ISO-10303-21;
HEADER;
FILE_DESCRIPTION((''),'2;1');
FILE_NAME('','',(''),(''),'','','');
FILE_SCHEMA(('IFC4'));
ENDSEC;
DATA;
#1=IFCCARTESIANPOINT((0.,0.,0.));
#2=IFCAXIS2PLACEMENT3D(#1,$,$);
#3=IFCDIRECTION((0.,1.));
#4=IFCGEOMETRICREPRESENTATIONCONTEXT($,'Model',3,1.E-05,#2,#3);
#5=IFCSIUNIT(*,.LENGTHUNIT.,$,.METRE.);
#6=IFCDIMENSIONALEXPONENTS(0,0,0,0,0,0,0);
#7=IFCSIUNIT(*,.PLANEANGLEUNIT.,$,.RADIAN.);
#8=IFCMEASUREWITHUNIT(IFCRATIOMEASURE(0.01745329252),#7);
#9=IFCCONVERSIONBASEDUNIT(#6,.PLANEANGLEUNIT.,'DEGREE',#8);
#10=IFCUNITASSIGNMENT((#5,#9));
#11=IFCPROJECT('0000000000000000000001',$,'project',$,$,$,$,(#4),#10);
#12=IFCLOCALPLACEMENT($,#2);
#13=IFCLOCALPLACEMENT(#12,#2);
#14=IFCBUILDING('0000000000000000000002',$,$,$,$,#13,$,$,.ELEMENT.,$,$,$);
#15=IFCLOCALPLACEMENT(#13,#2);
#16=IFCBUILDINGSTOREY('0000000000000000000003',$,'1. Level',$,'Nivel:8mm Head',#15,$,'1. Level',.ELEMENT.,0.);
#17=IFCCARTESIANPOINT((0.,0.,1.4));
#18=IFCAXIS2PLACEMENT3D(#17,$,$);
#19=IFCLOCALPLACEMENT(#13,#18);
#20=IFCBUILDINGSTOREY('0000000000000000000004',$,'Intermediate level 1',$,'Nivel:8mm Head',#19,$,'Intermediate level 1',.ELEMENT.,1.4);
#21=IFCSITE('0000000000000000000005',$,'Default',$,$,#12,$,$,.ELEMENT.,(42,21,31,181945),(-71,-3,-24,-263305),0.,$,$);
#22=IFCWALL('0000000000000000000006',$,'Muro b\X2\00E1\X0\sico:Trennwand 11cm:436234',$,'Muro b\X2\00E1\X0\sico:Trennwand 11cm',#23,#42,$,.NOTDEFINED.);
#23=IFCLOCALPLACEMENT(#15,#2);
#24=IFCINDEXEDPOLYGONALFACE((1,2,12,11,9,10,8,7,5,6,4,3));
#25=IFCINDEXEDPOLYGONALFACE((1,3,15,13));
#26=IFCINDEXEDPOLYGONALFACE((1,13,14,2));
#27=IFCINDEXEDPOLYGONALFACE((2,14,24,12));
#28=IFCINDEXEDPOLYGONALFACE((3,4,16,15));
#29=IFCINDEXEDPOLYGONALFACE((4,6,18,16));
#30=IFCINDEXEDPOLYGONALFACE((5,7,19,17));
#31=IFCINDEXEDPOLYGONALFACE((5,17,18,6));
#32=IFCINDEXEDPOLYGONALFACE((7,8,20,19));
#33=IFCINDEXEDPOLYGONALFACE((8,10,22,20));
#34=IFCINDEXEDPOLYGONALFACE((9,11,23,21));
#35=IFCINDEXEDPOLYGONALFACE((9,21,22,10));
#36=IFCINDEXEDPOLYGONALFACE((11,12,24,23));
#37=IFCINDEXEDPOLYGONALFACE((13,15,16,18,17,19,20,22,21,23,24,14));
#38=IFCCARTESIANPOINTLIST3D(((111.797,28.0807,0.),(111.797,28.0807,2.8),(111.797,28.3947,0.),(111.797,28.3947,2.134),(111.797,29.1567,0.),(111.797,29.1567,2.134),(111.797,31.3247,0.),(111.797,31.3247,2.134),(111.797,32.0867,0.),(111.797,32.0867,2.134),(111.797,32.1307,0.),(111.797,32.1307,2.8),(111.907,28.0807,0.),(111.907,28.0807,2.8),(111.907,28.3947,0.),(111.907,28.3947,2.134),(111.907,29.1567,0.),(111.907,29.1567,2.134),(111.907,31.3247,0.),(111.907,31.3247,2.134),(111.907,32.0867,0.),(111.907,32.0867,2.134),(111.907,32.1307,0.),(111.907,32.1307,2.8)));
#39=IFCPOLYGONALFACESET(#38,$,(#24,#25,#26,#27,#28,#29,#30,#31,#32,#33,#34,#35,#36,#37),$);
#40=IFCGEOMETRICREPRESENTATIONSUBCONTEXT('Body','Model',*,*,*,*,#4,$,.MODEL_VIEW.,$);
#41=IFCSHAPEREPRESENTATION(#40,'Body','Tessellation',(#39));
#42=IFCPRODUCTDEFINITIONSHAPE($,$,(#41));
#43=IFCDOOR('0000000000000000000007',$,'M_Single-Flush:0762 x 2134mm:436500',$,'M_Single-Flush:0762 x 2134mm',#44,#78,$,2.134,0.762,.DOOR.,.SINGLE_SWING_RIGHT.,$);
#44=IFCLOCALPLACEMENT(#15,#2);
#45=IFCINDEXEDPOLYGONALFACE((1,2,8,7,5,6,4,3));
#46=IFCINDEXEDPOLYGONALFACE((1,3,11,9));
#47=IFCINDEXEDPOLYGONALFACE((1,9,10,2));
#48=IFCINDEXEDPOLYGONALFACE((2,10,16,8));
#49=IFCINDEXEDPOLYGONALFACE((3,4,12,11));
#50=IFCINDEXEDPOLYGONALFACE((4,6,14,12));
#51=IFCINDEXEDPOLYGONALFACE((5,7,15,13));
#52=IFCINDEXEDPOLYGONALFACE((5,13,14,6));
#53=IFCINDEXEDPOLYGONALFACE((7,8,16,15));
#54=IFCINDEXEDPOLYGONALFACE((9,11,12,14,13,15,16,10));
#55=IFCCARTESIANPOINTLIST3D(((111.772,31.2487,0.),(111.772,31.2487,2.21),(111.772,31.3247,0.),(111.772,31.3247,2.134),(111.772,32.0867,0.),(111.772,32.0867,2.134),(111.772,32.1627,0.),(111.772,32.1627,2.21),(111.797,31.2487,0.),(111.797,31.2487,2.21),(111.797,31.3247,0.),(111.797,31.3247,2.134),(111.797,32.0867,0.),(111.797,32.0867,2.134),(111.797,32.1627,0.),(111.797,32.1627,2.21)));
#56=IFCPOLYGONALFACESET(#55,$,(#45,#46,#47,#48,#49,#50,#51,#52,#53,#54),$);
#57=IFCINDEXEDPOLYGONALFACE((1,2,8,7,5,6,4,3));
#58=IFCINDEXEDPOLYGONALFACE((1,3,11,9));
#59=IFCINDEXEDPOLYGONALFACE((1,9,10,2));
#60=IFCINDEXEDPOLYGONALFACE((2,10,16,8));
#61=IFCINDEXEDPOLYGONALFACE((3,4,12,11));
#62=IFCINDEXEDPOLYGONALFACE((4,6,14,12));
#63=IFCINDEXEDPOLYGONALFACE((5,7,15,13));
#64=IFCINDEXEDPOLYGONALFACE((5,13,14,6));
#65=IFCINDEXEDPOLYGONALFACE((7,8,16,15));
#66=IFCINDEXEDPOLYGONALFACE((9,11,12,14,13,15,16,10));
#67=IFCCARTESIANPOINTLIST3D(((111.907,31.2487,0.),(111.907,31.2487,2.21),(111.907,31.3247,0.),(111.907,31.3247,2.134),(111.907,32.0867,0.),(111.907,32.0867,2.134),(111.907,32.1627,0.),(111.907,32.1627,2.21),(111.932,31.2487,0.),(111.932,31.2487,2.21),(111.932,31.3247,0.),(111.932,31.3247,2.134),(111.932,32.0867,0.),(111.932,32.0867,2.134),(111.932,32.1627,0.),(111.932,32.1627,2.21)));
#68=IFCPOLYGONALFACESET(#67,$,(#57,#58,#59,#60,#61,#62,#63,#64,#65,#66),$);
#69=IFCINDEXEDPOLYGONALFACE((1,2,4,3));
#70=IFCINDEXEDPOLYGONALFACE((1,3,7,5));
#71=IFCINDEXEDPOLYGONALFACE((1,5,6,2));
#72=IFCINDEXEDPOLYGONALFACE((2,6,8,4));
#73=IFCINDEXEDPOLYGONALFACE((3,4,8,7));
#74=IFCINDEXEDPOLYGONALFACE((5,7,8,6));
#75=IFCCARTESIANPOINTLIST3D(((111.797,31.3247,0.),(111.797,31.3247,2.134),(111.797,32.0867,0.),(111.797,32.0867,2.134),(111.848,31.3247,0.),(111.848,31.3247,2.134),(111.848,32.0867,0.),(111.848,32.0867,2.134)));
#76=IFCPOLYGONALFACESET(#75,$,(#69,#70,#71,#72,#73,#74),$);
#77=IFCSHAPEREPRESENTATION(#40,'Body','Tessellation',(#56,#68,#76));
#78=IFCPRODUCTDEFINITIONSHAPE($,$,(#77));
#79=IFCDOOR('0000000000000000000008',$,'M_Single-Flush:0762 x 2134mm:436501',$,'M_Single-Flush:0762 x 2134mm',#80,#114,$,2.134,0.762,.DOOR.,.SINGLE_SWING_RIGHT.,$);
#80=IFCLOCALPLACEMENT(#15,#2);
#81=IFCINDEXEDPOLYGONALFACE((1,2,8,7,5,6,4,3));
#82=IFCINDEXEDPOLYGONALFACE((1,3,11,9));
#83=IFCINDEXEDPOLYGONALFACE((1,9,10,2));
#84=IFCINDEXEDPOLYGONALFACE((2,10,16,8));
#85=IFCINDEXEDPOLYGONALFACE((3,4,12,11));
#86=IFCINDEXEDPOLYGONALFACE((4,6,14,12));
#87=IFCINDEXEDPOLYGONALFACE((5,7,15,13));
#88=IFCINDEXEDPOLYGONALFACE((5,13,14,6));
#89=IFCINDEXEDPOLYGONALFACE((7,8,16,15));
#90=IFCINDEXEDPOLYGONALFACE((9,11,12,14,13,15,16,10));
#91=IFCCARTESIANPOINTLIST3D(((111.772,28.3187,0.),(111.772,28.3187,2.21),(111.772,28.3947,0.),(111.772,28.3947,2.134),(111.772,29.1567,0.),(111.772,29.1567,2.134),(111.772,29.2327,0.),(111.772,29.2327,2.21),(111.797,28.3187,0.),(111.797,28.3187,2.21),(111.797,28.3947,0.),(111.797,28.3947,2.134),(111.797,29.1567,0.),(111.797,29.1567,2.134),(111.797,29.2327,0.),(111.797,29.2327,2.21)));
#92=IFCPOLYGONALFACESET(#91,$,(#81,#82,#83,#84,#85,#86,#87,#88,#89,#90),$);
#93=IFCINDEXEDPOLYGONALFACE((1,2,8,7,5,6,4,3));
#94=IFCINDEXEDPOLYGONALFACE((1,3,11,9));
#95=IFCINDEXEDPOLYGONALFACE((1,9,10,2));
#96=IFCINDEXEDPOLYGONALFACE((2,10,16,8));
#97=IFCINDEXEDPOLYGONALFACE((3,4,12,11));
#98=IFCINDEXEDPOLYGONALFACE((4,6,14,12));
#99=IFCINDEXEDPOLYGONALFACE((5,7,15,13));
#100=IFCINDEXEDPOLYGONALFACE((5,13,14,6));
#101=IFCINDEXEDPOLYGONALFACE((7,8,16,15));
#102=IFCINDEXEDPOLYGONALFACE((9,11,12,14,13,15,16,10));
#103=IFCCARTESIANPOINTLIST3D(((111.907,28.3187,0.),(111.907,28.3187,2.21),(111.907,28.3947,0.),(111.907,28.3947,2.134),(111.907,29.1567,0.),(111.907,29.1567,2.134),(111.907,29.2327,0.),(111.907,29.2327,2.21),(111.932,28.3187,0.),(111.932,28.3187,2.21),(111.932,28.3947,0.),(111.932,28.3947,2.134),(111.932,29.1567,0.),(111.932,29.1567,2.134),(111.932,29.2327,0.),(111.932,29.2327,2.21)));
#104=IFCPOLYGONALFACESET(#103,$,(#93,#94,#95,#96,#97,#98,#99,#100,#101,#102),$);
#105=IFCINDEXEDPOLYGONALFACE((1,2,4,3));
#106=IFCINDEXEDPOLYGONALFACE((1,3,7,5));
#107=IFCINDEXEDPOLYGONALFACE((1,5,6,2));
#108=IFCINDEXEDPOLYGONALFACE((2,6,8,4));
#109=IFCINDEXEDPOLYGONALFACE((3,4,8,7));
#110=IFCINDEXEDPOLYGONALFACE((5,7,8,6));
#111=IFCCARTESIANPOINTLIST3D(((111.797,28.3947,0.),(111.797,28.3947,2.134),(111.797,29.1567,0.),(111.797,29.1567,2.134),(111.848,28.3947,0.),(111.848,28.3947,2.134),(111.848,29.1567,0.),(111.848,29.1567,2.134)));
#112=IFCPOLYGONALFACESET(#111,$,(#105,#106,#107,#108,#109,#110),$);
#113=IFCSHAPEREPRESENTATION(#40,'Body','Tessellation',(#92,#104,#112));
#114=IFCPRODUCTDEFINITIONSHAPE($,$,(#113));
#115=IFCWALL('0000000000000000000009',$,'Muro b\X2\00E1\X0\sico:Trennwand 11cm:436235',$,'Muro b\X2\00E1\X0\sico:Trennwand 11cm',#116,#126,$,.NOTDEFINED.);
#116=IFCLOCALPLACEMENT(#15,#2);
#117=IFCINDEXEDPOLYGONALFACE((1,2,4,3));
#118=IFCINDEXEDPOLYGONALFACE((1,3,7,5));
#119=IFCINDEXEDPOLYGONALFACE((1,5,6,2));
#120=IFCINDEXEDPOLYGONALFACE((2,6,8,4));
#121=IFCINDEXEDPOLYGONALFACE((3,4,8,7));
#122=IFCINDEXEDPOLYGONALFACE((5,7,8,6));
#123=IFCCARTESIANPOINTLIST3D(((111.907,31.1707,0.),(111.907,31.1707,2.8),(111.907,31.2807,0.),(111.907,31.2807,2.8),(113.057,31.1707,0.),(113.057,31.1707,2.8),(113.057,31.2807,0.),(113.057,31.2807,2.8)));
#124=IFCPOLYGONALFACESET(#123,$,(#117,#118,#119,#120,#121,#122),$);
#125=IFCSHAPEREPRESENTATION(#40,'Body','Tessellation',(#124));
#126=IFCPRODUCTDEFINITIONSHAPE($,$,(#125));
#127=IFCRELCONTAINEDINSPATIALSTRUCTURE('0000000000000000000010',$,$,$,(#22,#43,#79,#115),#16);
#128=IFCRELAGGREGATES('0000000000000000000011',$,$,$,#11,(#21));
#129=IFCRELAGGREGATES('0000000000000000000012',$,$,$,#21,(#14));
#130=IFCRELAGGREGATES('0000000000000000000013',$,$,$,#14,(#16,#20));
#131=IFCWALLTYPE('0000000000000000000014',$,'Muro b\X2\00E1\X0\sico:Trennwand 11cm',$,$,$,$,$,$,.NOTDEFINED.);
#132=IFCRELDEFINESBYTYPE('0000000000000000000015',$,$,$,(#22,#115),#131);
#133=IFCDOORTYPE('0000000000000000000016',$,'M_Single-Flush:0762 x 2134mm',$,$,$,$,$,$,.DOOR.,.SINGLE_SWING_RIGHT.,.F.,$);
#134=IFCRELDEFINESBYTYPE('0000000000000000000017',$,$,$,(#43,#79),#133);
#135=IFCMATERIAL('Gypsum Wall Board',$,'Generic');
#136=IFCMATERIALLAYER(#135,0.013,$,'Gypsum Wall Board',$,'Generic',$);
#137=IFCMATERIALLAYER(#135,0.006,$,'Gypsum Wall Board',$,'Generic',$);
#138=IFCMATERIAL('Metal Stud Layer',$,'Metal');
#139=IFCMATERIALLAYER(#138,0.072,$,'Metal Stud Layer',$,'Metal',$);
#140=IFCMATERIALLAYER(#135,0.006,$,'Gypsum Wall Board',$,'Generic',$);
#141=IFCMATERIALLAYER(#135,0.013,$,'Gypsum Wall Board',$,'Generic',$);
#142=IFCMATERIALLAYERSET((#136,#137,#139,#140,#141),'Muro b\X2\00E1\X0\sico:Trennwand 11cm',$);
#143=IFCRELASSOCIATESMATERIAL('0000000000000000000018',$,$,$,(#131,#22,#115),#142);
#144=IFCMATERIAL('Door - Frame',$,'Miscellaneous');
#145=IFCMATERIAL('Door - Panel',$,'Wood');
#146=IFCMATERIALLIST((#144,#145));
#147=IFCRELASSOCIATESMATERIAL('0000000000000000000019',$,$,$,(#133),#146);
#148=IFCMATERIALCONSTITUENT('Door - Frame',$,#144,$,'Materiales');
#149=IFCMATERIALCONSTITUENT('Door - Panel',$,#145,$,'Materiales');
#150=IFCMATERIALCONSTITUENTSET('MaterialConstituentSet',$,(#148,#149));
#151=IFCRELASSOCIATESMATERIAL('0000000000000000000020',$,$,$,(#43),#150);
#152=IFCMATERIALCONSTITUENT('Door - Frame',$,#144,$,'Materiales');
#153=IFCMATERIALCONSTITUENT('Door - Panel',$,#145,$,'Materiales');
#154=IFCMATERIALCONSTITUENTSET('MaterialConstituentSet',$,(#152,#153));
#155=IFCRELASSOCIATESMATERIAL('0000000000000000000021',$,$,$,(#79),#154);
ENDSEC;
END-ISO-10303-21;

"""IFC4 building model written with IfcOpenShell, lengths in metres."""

from ifc_helpers import new_model, entity, si_unit, converted_unit, direction, frame, frame_2d, origin, origin_2d_with_axis, place, context, subcontext, project, spatial, polyline, rectangle, outline, extrude, source, transform, mapped, material, material_list, layer, layer_set, layer_usage, constituent, constituent_set, type_object, type_shapes, element, fill, save


model = new_model("IFC4")

# Units and contexts
model_context = context("Model", 3, precision=1e-05, world=origin(), true_north=direction((0.0, 1.0)))
body_context = subcontext(model_context, "Body", "Model", "MODEL_VIEW")
ifc_project = project(units=[si_unit("LENGTHUNIT", "METRE"), converted_unit("PLANEANGLEUNIT", "DEGREE", entity("IfcRatioMeasure", 0.01745329252), si_unit("PLANEANGLEUNIT", "RADIAN"), dimensions=[0, 0, 0, 0, 0, 0, 0])], contexts=[model_context])

# Site, building, storey
site_placement = place(None, origin())
site = spatial("IfcSite", under=ifc_project, at=site_placement, Name="Default", CompositionType="ELEMENT", RefLatitude=(42, 21, 31, 181945), RefLongitude=(-71, -3, -24, -263305), RefElevation=0.0)
building_placement = place(site_placement, origin())
building = spatial("IfcBuilding", under=site, at=building_placement, CompositionType="ELEMENT")
storey_1_placement = place(building_placement, origin())
storey_1 = spatial("IfcBuildingStorey", under=building, at=storey_1_placement, Name="1. Level", ObjectType="Nivel:8mm Head", LongName="1. Level", CompositionType="ELEMENT", Elevation=0.0)

# Shared definitions
storey_2_placement = place(building_placement, frame((0.0, 0.0, 1.4)))
storey_2 = spatial("IfcBuildingStorey", under=building, at=storey_2_placement, Name="Intermediate level 1", ObjectType="Nivel:8mm Head", LongName="Intermediate level 1", CompositionType="ELEMENT", Elevation=1.4)

# Shared definitions
ifc_material_1 = material(Name="Gypsum Wall Board", Category="Generic")
ifc_layer_1 = layer(ifc_material_1, 0.013, Name="Gypsum Wall Board", Category="Generic")
ifc_layer_2 = layer(ifc_material_1, 0.006, Name="Gypsum Wall Board", Category="Generic")
ifc_material_2 = material(Name="Metal Stud Layer", Category="Metal")
ifc_layer_3 = layer(ifc_material_2, 0.072, Name="Metal Stud Layer", Category="Metal")
ifc_layer_4 = layer(ifc_material_1, 0.006, Name="Gypsum Wall Board", Category="Generic")
ifc_layer_5 = layer(ifc_material_1, 0.013, Name="Gypsum Wall Board", Category="Generic")
ifc_layer_set_1 = layer_set([ifc_layer_1, ifc_layer_2, ifc_layer_3, ifc_layer_4, ifc_layer_5], Name="Muro básico:Trennwand 11cm")
wall_type_1 = type_object("IfcWallType", Name="Muro básico:Trennwand 11cm", PredefinedType="NOTDEFINED", material=ifc_layer_set_1)
ifc_material_3 = material(Name="Door - Frame", Category="Miscellaneous")
ifc_material_4 = material(Name="Door - Panel", Category="Wood")
ifc_material_list_1 = material_list([ifc_material_3, ifc_material_4])
door_type_1 = type_object("IfcDoorType", Name="M_Single-Flush:0762 x 2134mm", OperationType="SINGLE_SWING_RIGHT", ParameterTakesPrecedence=False, PredefinedType="DOOR", material=ifc_material_list_1)
shared_shape_1 = source(origin(), body_context, "Body", "SweptSolid", [
    extrude(outline(polyline([(-0.457, -1.124), (0.457, -1.124), (0.457, 1.086), (0.381, 1.086), (0.381, -1.048), (-0.381, -1.048), (-0.381, 1.086), (-0.457, 1.086), (-0.457, -1.124)])), frame((0.381, 0.11, 1.086), z_axis=(0.0, 1.0, 0.0), x_axis=(1.0, 0.0, 0.0)), (0.0, 0.0, 1.0), 0.025),
    extrude(outline(polyline([(-1.124, -0.457), (1.086, -0.457), (1.086, -0.381), (-1.048, -0.381), (-1.048, 0.381), (1.086, 0.381), (1.086, 0.457), (-1.124, 0.457), (-1.124, -0.457)])), frame((0.381, -0.025, 1.086), z_axis=(0.0, 1.0, 0.0), x_axis=(0.0, 0.0, -1.0)), (0.0, 0.0, 1.0), 0.025),
    extrude(rectangle(XDim=0.051, YDim=0.762, at=origin_2d_with_axis()), frame((0.381, 0.0845, 0.0), z_axis=(0.0, 0.0, 1.0), x_axis=(0.0, 1.0, 0.0)), (0.0, 0.0, 1.0), 2.134),
])
type_shapes(door_type_1, [shared_shape_1])

# Wall, openings, doors
ifc_layer_usage_1 = layer_usage(ifc_layer_set_1, "AXIS2", "NEGATIVE", 0.055)
wall_1_placement = place(storey_1_placement, frame((111.852, 28.0807, 0.0), z_axis=(0.0, 0.0, 1.0), x_axis=(0.0, 1.0, 0.0)))
wall_1 = element("IfcWall", 1, at=wall_1_placement, inside=storey_1, type_object=wall_type_1, material=ifc_layer_usage_1, Name="Muro básico:Trennwand 11cm:436234", ObjectType="Muro básico:Trennwand 11cm", PredefinedType="NOTDEFINED", context=body_context, shape_type="SweptSolid", body=[
    extrude(rectangle(XDim=4.05, YDim=0.11, at=frame_2d((2.025, 0.0), x_axis=(-1.0, 0.0))), origin(), (0.0, 0.0, 1.0), 2.8),
])
opening_1_placement = place(wall_1_placement, frame((3.244, -0.055, 0.0)))
opening_1 = element("IfcOpeningElement", 2, at=opening_1_placement, cuts=wall_1, ObjectType="Opening", PredefinedType="OPENING", context=body_context, shape_type="SweptSolid", body=[
    extrude(rectangle(XDim=0.762, YDim=2.134, at=frame_2d((1.067, 0.381), x_axis=(0.0, 1.0))), frame((0.0, 0.0, 0.0), z_axis=(0.0, 1.0, 0.0), x_axis=(0.0, 0.0, 1.0)), (0.0, 0.0, 1.0), 0.11),
])
opening_2_placement = place(wall_1_placement, frame((0.314, -0.055, 0.0)))
opening_2 = element("IfcOpeningElement", 3, at=opening_2_placement, cuts=wall_1, ObjectType="Opening", PredefinedType="OPENING", context=body_context, shape_type="SweptSolid", body=[
    extrude(rectangle(XDim=0.762, YDim=2.134, at=frame_2d((1.067, 0.381), x_axis=(0.0, 1.0))), frame((0.0, 0.0, 0.0), z_axis=(0.0, 1.0, 0.0), x_axis=(0.0, 0.0, 1.0)), (0.0, 0.0, 1.0), 0.11),
])
ifc_constituent_1 = constituent(ifc_material_3, Name="Door - Frame", Category="Materiales")
ifc_constituent_2 = constituent(ifc_material_4, Name="Door - Panel", Category="Materiales")
ifc_constituent_set_1 = constituent_set(constituents=[ifc_constituent_1, ifc_constituent_2], Name="MaterialConstituentSet")
door_1_placement = place(opening_1_placement, origin())
door_1 = element("IfcDoor", 4, at=door_1_placement, inside=storey_1, type_object=door_type_1, material=ifc_constituent_set_1, Name="M_Single-Flush:0762 x 2134mm:436500", ObjectType="M_Single-Flush:0762 x 2134mm", OperationType="SINGLE_SWING_RIGHT", OverallHeight=2.134, OverallWidth=0.762, PredefinedType="DOOR", context=body_context, shape_type="MappedRepresentation", body=[
    mapped(shared_shape_1, transform((0.0, 0.0, 0.0), scale=1.0)),
])
fill(opening_1, door_1)
ifc_constituent_3 = constituent(ifc_material_3, Name="Door - Frame", Category="Materiales")
ifc_constituent_4 = constituent(ifc_material_4, Name="Door - Panel", Category="Materiales")
ifc_constituent_set_2 = constituent_set(constituents=[ifc_constituent_3, ifc_constituent_4], Name="MaterialConstituentSet")
door_2_placement = place(opening_2_placement, origin())
door_2 = element("IfcDoor", 5, at=door_2_placement, inside=storey_1, type_object=door_type_1, material=ifc_constituent_set_2, Name="M_Single-Flush:0762 x 2134mm:436501", ObjectType="M_Single-Flush:0762 x 2134mm", OperationType="SINGLE_SWING_RIGHT", OverallHeight=2.134, OverallWidth=0.762, PredefinedType="DOOR", context=body_context, shape_type="MappedRepresentation", body=[
    mapped(shared_shape_1, transform((0.0, 0.0, 0.0), scale=1.0)),
])
fill(opening_2, door_2)

# Wall
ifc_layer_usage_2 = layer_usage(ifc_layer_set_1, "AXIS2", "NEGATIVE", 0.055)
wall_2_placement = place(storey_1_placement, frame((111.907, 31.2257, 0.0)))
element("IfcWall", 6, at=wall_2_placement, inside=storey_1, type_object=wall_type_1, material=ifc_layer_usage_2, Name="Muro básico:Trennwand 11cm:436235", ObjectType="Muro básico:Trennwand 11cm", PredefinedType="NOTDEFINED", context=body_context, shape_type="SweptSolid", body=[
    extrude(rectangle(XDim=1.15, YDim=0.11, at=frame_2d((0.575, 0.0), x_axis=(-1.0, 0.0))), origin(), (0.0, 0.0, 1.0), 2.8),
])

save(model, "model.ifc")
